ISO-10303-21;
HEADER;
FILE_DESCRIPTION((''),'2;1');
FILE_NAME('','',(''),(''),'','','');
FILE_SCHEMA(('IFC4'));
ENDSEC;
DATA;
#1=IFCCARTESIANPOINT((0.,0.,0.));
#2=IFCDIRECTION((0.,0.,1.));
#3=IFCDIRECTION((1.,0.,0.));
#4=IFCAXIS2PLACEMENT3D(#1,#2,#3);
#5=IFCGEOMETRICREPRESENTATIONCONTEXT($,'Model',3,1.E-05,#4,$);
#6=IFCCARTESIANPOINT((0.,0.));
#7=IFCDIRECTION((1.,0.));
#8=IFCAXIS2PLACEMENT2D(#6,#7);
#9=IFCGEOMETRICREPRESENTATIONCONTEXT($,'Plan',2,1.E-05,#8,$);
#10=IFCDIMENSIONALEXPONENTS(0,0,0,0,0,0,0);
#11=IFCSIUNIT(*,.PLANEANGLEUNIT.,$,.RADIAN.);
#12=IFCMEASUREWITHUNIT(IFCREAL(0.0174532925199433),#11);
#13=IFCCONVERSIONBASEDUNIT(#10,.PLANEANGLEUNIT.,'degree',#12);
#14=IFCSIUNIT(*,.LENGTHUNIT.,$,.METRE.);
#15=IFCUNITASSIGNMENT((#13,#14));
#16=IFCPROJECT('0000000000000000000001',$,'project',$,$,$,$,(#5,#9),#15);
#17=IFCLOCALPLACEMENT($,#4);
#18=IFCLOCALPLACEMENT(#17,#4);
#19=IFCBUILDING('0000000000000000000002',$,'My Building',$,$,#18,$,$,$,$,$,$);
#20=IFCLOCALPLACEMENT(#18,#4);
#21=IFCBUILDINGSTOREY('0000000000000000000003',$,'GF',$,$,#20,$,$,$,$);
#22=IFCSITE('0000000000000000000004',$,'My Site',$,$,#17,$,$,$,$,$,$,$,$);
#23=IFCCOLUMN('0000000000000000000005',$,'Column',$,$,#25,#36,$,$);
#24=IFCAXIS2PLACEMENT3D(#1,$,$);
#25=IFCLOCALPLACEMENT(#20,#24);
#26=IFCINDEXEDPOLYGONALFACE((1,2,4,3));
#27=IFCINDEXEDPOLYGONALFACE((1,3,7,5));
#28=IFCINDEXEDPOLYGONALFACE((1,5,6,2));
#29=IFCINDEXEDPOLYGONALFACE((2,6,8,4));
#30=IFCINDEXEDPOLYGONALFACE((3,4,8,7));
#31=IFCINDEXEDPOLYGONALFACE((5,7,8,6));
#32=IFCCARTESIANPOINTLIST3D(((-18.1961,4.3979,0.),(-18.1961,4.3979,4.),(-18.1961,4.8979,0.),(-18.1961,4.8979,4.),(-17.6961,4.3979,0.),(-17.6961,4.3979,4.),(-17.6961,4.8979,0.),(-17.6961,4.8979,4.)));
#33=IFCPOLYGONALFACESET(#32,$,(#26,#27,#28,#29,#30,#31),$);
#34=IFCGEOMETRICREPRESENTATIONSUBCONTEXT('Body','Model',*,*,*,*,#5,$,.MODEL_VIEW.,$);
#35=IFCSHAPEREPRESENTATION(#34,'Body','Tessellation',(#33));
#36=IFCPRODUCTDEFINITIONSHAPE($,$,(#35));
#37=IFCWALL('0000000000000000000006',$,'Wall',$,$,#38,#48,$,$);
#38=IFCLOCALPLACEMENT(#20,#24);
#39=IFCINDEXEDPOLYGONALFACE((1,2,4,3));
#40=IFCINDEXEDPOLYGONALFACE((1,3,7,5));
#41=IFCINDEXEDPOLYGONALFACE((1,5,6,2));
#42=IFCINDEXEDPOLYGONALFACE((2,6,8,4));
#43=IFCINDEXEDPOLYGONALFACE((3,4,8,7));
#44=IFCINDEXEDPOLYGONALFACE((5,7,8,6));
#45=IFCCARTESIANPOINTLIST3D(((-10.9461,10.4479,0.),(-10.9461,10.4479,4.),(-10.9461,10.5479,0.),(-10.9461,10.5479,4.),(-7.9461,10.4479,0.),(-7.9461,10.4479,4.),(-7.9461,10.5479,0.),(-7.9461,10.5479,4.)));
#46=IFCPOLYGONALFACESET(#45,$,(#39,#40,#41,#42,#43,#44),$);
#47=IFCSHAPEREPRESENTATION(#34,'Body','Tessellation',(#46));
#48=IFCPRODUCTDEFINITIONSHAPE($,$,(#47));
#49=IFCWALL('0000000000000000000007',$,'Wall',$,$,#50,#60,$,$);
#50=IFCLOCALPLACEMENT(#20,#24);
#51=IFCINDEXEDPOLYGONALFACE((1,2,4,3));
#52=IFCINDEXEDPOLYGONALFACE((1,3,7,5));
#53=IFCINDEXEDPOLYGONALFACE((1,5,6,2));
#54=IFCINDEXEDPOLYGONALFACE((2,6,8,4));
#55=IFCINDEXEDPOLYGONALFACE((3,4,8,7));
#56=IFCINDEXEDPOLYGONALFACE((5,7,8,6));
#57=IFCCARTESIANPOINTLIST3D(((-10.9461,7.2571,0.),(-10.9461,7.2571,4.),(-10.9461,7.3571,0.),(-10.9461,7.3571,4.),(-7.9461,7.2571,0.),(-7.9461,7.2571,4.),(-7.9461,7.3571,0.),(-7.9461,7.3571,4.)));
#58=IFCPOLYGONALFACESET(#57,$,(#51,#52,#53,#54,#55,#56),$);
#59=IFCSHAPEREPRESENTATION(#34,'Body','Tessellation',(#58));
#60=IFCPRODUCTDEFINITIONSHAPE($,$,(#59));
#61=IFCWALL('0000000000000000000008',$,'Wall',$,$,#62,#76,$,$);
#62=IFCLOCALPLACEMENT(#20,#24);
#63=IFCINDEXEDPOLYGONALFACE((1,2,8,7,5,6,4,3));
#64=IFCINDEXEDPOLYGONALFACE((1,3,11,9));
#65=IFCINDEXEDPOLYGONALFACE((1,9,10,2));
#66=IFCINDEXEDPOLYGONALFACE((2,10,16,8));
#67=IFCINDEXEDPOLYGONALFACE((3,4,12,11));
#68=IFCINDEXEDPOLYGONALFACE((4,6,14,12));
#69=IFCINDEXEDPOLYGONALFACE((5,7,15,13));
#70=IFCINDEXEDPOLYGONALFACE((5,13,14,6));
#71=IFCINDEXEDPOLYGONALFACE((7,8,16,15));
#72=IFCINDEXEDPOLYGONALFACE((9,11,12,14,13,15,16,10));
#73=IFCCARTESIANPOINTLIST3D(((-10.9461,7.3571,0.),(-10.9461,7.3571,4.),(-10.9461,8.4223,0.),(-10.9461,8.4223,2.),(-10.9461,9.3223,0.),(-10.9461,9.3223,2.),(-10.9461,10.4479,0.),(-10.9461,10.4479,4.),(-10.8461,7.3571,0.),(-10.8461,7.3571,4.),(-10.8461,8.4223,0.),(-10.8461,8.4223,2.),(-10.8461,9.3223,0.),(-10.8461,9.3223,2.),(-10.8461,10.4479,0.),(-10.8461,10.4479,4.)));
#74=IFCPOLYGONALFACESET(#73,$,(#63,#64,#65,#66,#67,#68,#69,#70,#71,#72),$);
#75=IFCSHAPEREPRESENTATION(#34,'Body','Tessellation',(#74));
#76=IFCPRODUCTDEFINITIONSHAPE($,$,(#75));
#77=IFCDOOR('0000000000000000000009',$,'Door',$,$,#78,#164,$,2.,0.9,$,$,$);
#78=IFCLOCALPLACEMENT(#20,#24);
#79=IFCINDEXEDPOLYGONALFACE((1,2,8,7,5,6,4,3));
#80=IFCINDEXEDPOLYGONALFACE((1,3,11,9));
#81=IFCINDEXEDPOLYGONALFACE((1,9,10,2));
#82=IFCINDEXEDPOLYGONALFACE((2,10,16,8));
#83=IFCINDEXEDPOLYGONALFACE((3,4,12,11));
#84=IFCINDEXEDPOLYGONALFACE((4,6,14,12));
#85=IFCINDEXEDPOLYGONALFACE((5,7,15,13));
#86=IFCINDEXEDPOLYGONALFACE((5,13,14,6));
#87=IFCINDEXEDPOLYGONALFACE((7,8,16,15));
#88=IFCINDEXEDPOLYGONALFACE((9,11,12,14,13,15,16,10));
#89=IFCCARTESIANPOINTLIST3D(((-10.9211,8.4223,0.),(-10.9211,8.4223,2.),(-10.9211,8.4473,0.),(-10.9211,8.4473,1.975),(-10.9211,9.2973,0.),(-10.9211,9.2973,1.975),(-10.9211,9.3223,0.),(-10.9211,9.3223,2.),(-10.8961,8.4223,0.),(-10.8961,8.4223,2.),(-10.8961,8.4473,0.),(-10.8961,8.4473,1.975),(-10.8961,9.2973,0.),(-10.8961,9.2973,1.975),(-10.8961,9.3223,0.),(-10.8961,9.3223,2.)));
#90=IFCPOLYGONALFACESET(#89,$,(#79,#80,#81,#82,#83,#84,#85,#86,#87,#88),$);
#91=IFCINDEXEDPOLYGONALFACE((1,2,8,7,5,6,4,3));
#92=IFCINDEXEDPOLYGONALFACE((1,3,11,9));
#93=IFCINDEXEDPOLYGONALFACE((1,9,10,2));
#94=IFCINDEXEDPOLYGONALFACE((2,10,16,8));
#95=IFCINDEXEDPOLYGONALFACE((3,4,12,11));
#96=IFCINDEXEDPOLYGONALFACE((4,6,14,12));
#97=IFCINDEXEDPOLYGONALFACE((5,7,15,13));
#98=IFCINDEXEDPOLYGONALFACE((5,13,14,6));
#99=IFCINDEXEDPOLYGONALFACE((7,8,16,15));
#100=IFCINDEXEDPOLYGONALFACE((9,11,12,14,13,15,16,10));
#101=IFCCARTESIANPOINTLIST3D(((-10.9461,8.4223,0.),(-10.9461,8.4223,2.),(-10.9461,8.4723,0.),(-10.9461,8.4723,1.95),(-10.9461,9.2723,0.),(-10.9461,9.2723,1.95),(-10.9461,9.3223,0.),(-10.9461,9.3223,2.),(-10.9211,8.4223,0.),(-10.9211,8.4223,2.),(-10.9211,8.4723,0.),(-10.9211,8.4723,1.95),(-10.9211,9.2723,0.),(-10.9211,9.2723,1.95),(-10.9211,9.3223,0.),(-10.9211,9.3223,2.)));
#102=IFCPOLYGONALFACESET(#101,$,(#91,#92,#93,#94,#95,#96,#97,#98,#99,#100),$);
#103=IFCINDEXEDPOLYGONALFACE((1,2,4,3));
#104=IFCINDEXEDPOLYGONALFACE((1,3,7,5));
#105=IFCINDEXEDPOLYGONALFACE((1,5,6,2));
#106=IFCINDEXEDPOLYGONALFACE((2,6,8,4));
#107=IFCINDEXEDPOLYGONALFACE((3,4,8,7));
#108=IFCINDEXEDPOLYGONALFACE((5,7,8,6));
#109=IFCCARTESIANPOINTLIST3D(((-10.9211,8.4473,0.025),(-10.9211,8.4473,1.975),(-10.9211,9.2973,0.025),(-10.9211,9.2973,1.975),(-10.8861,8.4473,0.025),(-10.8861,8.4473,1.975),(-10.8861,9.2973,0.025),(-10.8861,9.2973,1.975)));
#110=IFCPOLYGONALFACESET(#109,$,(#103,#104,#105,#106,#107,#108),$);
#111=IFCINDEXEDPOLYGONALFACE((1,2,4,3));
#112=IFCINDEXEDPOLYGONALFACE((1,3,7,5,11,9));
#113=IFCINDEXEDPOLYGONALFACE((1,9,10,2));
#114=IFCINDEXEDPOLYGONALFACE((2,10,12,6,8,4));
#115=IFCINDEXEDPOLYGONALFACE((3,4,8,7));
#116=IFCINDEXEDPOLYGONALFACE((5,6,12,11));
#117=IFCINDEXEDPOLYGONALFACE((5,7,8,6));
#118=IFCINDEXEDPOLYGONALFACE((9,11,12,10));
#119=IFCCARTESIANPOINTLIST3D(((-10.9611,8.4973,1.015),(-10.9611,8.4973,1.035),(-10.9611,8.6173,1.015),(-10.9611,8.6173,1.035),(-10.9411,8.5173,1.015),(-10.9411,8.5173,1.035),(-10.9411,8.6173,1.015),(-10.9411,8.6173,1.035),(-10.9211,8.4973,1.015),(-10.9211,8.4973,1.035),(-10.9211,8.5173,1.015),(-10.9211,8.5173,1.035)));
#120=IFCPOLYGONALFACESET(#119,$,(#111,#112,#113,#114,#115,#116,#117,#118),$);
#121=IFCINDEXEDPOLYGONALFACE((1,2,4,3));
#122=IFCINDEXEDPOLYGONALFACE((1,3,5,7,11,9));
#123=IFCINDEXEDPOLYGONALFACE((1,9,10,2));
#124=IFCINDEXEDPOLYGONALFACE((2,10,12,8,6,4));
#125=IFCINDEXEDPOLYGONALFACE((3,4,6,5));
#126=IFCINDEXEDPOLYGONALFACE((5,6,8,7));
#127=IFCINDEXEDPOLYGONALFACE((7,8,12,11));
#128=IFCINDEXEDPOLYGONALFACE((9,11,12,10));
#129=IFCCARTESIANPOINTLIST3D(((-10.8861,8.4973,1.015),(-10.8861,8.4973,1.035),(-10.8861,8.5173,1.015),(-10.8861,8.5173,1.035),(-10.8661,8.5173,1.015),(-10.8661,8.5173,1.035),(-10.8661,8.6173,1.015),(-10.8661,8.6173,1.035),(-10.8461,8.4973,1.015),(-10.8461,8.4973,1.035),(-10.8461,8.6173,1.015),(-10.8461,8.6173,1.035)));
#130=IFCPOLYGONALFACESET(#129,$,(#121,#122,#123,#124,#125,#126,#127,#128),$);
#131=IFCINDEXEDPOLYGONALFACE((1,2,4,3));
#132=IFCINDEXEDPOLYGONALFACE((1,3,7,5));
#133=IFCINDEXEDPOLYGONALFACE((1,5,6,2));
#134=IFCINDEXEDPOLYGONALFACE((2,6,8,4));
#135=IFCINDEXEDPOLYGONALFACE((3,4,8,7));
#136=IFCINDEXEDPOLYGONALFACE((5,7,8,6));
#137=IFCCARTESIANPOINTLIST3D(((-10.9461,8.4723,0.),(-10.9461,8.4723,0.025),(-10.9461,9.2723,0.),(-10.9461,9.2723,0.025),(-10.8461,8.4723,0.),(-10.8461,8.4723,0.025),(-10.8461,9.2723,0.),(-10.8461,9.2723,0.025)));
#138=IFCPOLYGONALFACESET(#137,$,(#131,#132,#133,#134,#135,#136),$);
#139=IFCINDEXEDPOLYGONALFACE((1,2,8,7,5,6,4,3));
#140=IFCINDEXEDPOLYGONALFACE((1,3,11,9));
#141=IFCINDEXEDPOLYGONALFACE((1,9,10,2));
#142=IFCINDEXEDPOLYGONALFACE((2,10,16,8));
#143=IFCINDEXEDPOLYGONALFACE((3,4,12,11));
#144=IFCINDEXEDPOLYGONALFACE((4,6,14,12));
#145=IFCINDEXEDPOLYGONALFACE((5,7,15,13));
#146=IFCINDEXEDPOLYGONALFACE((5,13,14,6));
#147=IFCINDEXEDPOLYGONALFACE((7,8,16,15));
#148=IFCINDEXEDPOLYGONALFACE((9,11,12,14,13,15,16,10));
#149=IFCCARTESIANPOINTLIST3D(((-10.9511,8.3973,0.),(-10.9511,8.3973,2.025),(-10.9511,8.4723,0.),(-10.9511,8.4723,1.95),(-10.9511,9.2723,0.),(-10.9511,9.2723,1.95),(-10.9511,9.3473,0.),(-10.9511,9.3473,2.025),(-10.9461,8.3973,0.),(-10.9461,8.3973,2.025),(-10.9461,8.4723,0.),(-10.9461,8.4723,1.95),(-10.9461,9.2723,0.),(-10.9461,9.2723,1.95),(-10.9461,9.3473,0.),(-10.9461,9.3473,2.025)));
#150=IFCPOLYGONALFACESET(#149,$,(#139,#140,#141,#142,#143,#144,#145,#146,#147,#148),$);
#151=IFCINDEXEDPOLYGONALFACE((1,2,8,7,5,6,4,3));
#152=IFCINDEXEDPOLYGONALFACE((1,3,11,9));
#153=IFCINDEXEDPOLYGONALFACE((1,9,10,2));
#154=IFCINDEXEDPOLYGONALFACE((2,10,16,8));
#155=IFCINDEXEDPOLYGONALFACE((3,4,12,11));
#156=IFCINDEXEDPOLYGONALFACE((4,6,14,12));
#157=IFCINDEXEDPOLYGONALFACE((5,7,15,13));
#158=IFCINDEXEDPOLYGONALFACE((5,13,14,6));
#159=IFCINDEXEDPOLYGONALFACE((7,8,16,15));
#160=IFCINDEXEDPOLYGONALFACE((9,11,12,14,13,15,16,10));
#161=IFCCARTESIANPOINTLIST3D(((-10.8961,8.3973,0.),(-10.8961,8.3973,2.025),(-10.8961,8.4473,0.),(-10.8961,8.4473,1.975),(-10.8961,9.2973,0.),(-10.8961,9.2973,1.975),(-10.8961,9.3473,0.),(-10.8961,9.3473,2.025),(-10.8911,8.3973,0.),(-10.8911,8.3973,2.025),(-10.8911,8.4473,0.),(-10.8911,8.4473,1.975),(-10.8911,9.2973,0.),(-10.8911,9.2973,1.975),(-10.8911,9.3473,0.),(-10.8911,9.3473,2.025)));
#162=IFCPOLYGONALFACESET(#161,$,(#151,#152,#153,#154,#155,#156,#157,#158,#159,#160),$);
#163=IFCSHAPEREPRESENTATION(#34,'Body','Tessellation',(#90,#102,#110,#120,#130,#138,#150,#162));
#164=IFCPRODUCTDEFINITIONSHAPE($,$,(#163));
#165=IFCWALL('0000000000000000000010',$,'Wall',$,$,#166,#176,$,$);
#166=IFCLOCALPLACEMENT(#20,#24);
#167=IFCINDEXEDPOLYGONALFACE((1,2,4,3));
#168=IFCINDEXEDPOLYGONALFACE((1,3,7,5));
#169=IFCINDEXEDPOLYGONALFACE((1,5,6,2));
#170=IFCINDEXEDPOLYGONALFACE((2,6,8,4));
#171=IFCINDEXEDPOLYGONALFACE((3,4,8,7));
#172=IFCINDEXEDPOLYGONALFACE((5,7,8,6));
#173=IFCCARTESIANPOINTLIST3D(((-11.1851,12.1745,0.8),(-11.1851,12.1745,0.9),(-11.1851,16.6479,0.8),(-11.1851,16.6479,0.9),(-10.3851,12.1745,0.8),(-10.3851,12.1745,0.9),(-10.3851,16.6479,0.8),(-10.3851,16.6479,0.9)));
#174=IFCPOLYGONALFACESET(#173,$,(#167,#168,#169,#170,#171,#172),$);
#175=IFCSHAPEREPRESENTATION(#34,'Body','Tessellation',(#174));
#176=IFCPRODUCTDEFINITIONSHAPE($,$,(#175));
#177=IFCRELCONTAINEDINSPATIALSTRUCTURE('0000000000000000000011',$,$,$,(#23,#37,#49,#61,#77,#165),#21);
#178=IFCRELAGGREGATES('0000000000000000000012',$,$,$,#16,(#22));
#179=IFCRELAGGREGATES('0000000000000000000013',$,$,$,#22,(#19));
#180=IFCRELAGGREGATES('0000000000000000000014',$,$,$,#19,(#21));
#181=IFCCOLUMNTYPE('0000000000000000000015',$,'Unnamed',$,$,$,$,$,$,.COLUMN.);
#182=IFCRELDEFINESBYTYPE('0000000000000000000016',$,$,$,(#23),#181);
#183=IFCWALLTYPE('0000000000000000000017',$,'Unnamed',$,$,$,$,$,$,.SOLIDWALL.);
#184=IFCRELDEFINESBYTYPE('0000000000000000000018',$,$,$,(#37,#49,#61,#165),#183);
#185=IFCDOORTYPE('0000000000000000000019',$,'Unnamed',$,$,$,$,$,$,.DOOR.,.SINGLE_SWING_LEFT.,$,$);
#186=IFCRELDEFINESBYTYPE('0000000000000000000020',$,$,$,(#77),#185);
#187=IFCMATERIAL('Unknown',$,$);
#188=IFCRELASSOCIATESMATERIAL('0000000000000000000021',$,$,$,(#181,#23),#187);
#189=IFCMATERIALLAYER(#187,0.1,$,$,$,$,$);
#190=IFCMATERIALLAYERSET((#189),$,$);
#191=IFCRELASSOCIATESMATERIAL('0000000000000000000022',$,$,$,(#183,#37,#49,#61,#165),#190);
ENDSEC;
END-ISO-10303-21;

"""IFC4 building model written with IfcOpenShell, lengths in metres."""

from ifc_helpers import new_model, entity, si_unit, converted_unit, frame, origin_with_axes, origin_2d_with_axis, place, context, subcontext, project, spatial, line, indexed_curve, rectangle, outline, extrude, shape, source, transform, mapped, material, layer, layer_set, layer_usage, material_profile, profile_set, profile_usage, type_object, type_shapes, element, fill, save


model = new_model("IFC4")

# Units and contexts
model_context = context("Model", 3, precision=1e-05, world=origin_with_axes())
plan_context = context("Plan", 2, precision=1e-05, world=origin_2d_with_axis())
body_context_1 = subcontext(model_context, "Body", "Model", "MODEL_VIEW")
body_context_2 = subcontext(plan_context, "Body", "Plan", "PLAN_VIEW")
ifc_project = project(units=[converted_unit("PLANEANGLEUNIT", "degree", entity("IfcReal", 0.0174532925199433), si_unit("PLANEANGLEUNIT", "RADIAN"), dimensions=[0, 0, 0, 0, 0, 0, 0]), si_unit("LENGTHUNIT", "METRE")], contexts=[model_context, plan_context])

# Site, building, storey
site_placement = place(None, origin_with_axes())
site = spatial("IfcSite", under=ifc_project, at=site_placement, Name="My Site")
building_placement = place(site_placement, origin_with_axes())
building = spatial("IfcBuilding", under=site, at=building_placement, Name="My Building")
storey_placement = place(building_placement, origin_with_axes())
storey = spatial("IfcBuildingStorey", under=building, at=storey_placement, Name="GF")

# Column
ifc_material = material(Name="Unknown")
ifc_material_profile = material_profile(ifc_material, rectangle(XDim=0.5, YDim=0.5))
ifc_profile_set = profile_set([ifc_material_profile])
ifc_profile_usage = profile_usage(ifc_profile_set, cardinal=5)
column_type = type_object("IfcColumnType", Name="Unnamed", PredefinedType="COLUMN", material=ifc_profile_set)
column_placement = place(storey_placement, frame((-17.9461, 4.6479, 0.0), z_axis=(0.0, 0.0, 1.0), x_axis=(1.0, 0.0, 0.0)))
element("IfcColumn", 1, at=column_placement, inside=storey, type_object=column_type, material=ifc_profile_usage, Name="Column", context=body_context_1, shape_type="SweptSolid", body=[
    extrude(rectangle(XDim=0.5, YDim=0.5), origin_with_axes(), (0.0, 0.0, 1.0), 4.0),
])

# Walls
ifc_layer = layer(ifc_material, 0.1)
ifc_layer_set = layer_set([ifc_layer])
ifc_layer_usage_1 = layer_usage(ifc_layer_set, "AXIS2", "POSITIVE", 0.0)
wall_type = type_object("IfcWallType", Name="Unnamed", PredefinedType="SOLIDWALL", material=ifc_layer_set)
wall_1_placement = place(storey_placement, frame((-10.9461, 10.4479, 0.0), z_axis=(0.0, 0.0, 1.0), x_axis=(1.0, 0.0, 0.0)))
element("IfcWall", 2, at=wall_1_placement, inside=storey, type_object=wall_type, material=ifc_layer_usage_1, Name="Wall", context=body_context_1, shape_type="SweptSolid", body=[
    extrude(outline(indexed_curve([(0.0, 0.0), (0.0, 0.1), (3.0, 0.1), (3.0, 0.0)], segments=[line(1, 2, 3, 4, 1)])), origin_with_axes(), (0.0, 0.0, 1.0), 4.0),
])
ifc_layer_usage_2 = layer_usage(ifc_layer_set, "AXIS2", "POSITIVE", 0.0)
wall_2_placement = place(storey_placement, frame((-10.9461, 7.2571, 0.0), z_axis=(0.0, 0.0, 1.0), x_axis=(1.0, 0.0, 0.0)))
element("IfcWall", 3, at=wall_2_placement, inside=storey, type_object=wall_type, material=ifc_layer_usage_2, Name="Wall", context=body_context_1, shape_type="SweptSolid", body=[
    extrude(outline(indexed_curve([(0.0, 0.0), (0.0, 0.1), (3.0, 0.1), (3.0, 0.0)], segments=[line(1, 2, 3, 4, 1)])), origin_with_axes(), (0.0, 0.0, 1.0), 4.0),
])

# Wall, opening, door
ifc_layer_usage_3 = layer_usage(ifc_layer_set, "AXIS2", "POSITIVE", 0.0)
wall_3_placement = place(storey_placement, frame((-10.9461, 10.4479, 0.0), z_axis=(0.0, 0.0, 1.0), x_axis=(0.0, -1.0, 0.0)))
wall_3 = element("IfcWall", 4, at=wall_3_placement, inside=storey, type_object=wall_type, material=ifc_layer_usage_3, Name="Wall", context=body_context_1, shape_type="SweptSolid", body=[
    extrude(outline(indexed_curve([(0.0, 0.0), (0.0, 0.1), (3.0909, 0.1), (3.0909, 0.0)], segments=[line(1, 2, 3, 4, 1)])), origin_with_axes(), (0.0, 0.0, 1.0), 4.0),
])
shared_shape_1 = source(origin_with_axes(), body_context_1, "Body", "SweptSolid", [
    extrude(outline(indexed_curve([(0.0, 0.0), (0.9, 0.0), (0.9, 2.0), (0.0, 2.0)], segments=[line(1, 2, 3, 4, 1)])), frame((0.0, -0.6, 0.0), z_axis=(0.0, -1.0, 0.0), x_axis=(1.0, 0.0, 0.0)), (0.0, 0.0, -1.0), 1.2),
])
opening_placement = place(wall_3_placement, frame((1.1256, 0.0, 0.0), z_axis=(0.0, 0.0, 1.0), x_axis=(1.0, 0.0, 0.0)))
opening = element("IfcOpeningElement", 5, at=opening_placement, cuts=wall_3, PredefinedType="OPENING", context=body_context_1, shape_type="MappedRepresentation", body=[
    mapped(shared_shape_1, transform((0.0, 0.0, 0.0), x_axis=(1.0, 0.0, 0.0), y_axis=(0.0, 1.0, 0.0), z_axis=(0.0, 0.0, 1.0), scale=1.0)),
])
door_type = type_object("IfcDoorType", Name="Unnamed", OperationType="SINGLE_SWING_LEFT", PredefinedType="DOOR")
shared_shape_2 = source(origin_with_axes(), body_context_1, "Body", "SweptSolid", [
    extrude(outline(indexed_curve([(0.0, 0.0), (0.0, 2.0), (0.9, 2.0), (0.9, 0.0), (0.875, 0.0), (0.875, 1.975), (0.025, 1.975), (0.025, 0.0)], segments=[line(1, 2, 3, 4, 5, 6, 7, 8, 1)])), frame((0.0, 0.025, 0.0), z_axis=(0.0, -1.0, 0.0), x_axis=(1.0, 0.0, 0.0)), (0.0, 0.0, -1.0), 0.025),
    extrude(outline(indexed_curve([(0.0, 0.0), (0.0, 2.0), (0.9, 2.0), (0.9, 0.0), (0.85, 0.0), (0.85, 1.95), (0.05, 1.95), (0.05, 0.0)], segments=[line(1, 2, 3, 4, 5, 6, 7, 8, 1)])), frame((0.0, 0.0, 0.0), z_axis=(0.0, -1.0, 0.0), x_axis=(1.0, 0.0, 0.0)), (0.0, 0.0, -1.0), 0.025),
    extrude(outline(indexed_curve([(0.0, 0.0), (0.85, 0.0), (0.85, 0.035), (0.0, 0.035)], segments=[line(1, 2, 3, 4, 1)])), frame((0.025, 0.025, 0.025), z_axis=(0.0, 0.0, 1.0), x_axis=(1.0, 0.0, 0.0)), (0.0, 0.0, 1.0), 1.95),
    extrude(outline(indexed_curve([(0.0, 0.0), (0.0, -0.04), (-0.12, -0.04), (-0.12, -0.02), (-0.02, -0.02), (-0.02, 0.0)], segments=[line(1, 2, 3, 4, 5, 6, 1)])), frame((0.825, 0.025, 1.015), z_axis=(0.0, 0.0, 1.0), x_axis=(1.0, 0.0, 0.0)), (0.0, 0.0, 1.0), 0.02),
    extrude(outline(indexed_curve([(0.0, 0.0), (0.0, 0.04), (-0.12, 0.04), (-0.12, 0.02), (-0.02, 0.02), (-0.02, 0.0)], segments=[line(1, 2, 3, 4, 5, 6, 1)])), frame((0.825, 0.06, 1.015), z_axis=(0.0, 0.0, 1.0), x_axis=(1.0, 0.0, 0.0)), (0.0, 0.0, 1.0), 0.02),
    extrude(outline(indexed_curve([(0.0, 0.0), (0.8, 0.0), (0.8, 0.1), (0.0, 0.1)], segments=[line(1, 2, 3, 4, 1)])), frame((0.05, 0.0, 0.0), z_axis=(0.0, 0.0, 1.0), x_axis=(1.0, 0.0, 0.0)), (0.0, 0.0, 1.0), 0.025),
    extrude(outline(indexed_curve([(0.0, 0.0), (0.0, 2.025), (0.95, 2.025), (0.95, 0.0), (0.875, 0.0), (0.875, 1.95), (0.075, 1.95), (0.075, 0.0)], segments=[line(1, 2, 3, 4, 5, 6, 7, 8, 1)])), frame((-0.025, -0.005, 0.0), z_axis=(0.0, -1.0, 0.0), x_axis=(1.0, 0.0, 0.0)), (0.0, 0.0, -1.0), 0.005),
    extrude(outline(indexed_curve([(0.0, 0.0), (0.0, 2.025), (0.95, 2.025), (0.95, 0.0), (0.9, 0.0), (0.9, 1.975), (0.05, 1.975), (0.05, 0.0)], segments=[line(1, 2, 3, 4, 5, 6, 7, 8, 1)])), frame((-0.025, 0.05, 0.0), z_axis=(0.0, -1.0, 0.0), x_axis=(1.0, 0.0, 0.0)), (0.0, 0.0, -1.0), 0.005),
])
shared_shape_3 = source(origin_with_axes(), body_context_2, "Body", "Curve2D", [
    entity("IfcIndexedPolyCurve", entity("IfcCartesianPointList2D", [[0.0, 0.0], [0.0, 0.05], [0.025, 0.05], [0.025, 0.025], [0.05, 0.025], [0.05, 0.0]]), [entity("IfcLineIndex", [1, 2, 3, 4, 5, 6, 1])]),
    entity("IfcIndexedPolyCurve", entity("IfcCartesianPointList2D", [[0.9, 0.0], [0.9, 0.05], [0.875, 0.05], [0.875, 0.025], [0.85, 0.025], [0.85, 0.0]]), [entity("IfcLineIndex", [1, 2, 3, 4, 5, 6, 1])]),
    entity("IfcTrimmedCurve", entity("IfcEllipse", entity("IfcAxis2Placement2D", entity("IfcCartesianPoint", [0.06, 0.05]), entity("IfcDirection", [1.0, 0.0])), 0.815, 0.85), [entity("IfcCartesianPoint", [0.875, 0.05])], [entity("IfcCartesianPoint", [0.06, 0.9])], True, "CARTESIAN"),
    entity("IfcIndexedPolyCurve", entity("IfcCartesianPointList2D", [[0.025, 0.05], [0.06, 0.05], [0.06, 0.9], [0.025, 0.9]]), [entity("IfcLineIndex", [1, 2, 3, 4, 1])]),
])
type_shapes(door_type, [shared_shape_2, shared_shape_3])
door_placement = place(opening_placement, frame((0.0, 0.0, 0.0), z_axis=(0.0, 0.0, 1.0), x_axis=(1.0, 0.0, 0.0)))
door = element("IfcDoor", 6, at=door_placement, inside=storey, type_object=door_type, Name="Door", OverallHeight=2.0, OverallWidth=0.9, shapes=[
    shape(body_context_1, "Body", "MappedRepresentation", [mapped(shared_shape_2, transform((0.0, 0.0, 0.0), x_axis=(1.0, 0.0, 0.0), y_axis=(0.0, 1.0, 0.0), z_axis=(0.0, 0.0, 1.0), scale=1.0))]),
    shape(body_context_2, "Body", "MappedRepresentation", [mapped(shared_shape_3, transform((0.0, 0.0, 0.0), x_axis=(1.0, 0.0, 0.0), y_axis=(0.0, 1.0, 0.0), z_axis=(0.0, 0.0, 1.0), scale=1.0))]),
])
fill(opening, door)

# Wall
ifc_layer_usage_4 = layer_usage(ifc_layer_set, "AXIS2", "POSITIVE", 0.0)
wall_4_placement = place(storey_placement, frame((-11.1851, 12.1745, 0.8), z_axis=(1.0, 0.0, 0.0), x_axis=(0.0, 1.0, 0.0)))
element("IfcWall", 7, at=wall_4_placement, inside=storey, type_object=wall_type, material=ifc_layer_usage_4, Name="Wall", context=body_context_1, shape_type="SweptSolid", body=[
    extrude(outline(indexed_curve([(0.0, 0.0), (0.0, 0.1), (4.4734, 0.1), (4.4734, 0.0)], segments=[line(1, 2, 3, 4, 1)])), origin_with_axes(), (0.0, 0.0, 1.0), 0.8),
])

save(model, "model.ifc")
